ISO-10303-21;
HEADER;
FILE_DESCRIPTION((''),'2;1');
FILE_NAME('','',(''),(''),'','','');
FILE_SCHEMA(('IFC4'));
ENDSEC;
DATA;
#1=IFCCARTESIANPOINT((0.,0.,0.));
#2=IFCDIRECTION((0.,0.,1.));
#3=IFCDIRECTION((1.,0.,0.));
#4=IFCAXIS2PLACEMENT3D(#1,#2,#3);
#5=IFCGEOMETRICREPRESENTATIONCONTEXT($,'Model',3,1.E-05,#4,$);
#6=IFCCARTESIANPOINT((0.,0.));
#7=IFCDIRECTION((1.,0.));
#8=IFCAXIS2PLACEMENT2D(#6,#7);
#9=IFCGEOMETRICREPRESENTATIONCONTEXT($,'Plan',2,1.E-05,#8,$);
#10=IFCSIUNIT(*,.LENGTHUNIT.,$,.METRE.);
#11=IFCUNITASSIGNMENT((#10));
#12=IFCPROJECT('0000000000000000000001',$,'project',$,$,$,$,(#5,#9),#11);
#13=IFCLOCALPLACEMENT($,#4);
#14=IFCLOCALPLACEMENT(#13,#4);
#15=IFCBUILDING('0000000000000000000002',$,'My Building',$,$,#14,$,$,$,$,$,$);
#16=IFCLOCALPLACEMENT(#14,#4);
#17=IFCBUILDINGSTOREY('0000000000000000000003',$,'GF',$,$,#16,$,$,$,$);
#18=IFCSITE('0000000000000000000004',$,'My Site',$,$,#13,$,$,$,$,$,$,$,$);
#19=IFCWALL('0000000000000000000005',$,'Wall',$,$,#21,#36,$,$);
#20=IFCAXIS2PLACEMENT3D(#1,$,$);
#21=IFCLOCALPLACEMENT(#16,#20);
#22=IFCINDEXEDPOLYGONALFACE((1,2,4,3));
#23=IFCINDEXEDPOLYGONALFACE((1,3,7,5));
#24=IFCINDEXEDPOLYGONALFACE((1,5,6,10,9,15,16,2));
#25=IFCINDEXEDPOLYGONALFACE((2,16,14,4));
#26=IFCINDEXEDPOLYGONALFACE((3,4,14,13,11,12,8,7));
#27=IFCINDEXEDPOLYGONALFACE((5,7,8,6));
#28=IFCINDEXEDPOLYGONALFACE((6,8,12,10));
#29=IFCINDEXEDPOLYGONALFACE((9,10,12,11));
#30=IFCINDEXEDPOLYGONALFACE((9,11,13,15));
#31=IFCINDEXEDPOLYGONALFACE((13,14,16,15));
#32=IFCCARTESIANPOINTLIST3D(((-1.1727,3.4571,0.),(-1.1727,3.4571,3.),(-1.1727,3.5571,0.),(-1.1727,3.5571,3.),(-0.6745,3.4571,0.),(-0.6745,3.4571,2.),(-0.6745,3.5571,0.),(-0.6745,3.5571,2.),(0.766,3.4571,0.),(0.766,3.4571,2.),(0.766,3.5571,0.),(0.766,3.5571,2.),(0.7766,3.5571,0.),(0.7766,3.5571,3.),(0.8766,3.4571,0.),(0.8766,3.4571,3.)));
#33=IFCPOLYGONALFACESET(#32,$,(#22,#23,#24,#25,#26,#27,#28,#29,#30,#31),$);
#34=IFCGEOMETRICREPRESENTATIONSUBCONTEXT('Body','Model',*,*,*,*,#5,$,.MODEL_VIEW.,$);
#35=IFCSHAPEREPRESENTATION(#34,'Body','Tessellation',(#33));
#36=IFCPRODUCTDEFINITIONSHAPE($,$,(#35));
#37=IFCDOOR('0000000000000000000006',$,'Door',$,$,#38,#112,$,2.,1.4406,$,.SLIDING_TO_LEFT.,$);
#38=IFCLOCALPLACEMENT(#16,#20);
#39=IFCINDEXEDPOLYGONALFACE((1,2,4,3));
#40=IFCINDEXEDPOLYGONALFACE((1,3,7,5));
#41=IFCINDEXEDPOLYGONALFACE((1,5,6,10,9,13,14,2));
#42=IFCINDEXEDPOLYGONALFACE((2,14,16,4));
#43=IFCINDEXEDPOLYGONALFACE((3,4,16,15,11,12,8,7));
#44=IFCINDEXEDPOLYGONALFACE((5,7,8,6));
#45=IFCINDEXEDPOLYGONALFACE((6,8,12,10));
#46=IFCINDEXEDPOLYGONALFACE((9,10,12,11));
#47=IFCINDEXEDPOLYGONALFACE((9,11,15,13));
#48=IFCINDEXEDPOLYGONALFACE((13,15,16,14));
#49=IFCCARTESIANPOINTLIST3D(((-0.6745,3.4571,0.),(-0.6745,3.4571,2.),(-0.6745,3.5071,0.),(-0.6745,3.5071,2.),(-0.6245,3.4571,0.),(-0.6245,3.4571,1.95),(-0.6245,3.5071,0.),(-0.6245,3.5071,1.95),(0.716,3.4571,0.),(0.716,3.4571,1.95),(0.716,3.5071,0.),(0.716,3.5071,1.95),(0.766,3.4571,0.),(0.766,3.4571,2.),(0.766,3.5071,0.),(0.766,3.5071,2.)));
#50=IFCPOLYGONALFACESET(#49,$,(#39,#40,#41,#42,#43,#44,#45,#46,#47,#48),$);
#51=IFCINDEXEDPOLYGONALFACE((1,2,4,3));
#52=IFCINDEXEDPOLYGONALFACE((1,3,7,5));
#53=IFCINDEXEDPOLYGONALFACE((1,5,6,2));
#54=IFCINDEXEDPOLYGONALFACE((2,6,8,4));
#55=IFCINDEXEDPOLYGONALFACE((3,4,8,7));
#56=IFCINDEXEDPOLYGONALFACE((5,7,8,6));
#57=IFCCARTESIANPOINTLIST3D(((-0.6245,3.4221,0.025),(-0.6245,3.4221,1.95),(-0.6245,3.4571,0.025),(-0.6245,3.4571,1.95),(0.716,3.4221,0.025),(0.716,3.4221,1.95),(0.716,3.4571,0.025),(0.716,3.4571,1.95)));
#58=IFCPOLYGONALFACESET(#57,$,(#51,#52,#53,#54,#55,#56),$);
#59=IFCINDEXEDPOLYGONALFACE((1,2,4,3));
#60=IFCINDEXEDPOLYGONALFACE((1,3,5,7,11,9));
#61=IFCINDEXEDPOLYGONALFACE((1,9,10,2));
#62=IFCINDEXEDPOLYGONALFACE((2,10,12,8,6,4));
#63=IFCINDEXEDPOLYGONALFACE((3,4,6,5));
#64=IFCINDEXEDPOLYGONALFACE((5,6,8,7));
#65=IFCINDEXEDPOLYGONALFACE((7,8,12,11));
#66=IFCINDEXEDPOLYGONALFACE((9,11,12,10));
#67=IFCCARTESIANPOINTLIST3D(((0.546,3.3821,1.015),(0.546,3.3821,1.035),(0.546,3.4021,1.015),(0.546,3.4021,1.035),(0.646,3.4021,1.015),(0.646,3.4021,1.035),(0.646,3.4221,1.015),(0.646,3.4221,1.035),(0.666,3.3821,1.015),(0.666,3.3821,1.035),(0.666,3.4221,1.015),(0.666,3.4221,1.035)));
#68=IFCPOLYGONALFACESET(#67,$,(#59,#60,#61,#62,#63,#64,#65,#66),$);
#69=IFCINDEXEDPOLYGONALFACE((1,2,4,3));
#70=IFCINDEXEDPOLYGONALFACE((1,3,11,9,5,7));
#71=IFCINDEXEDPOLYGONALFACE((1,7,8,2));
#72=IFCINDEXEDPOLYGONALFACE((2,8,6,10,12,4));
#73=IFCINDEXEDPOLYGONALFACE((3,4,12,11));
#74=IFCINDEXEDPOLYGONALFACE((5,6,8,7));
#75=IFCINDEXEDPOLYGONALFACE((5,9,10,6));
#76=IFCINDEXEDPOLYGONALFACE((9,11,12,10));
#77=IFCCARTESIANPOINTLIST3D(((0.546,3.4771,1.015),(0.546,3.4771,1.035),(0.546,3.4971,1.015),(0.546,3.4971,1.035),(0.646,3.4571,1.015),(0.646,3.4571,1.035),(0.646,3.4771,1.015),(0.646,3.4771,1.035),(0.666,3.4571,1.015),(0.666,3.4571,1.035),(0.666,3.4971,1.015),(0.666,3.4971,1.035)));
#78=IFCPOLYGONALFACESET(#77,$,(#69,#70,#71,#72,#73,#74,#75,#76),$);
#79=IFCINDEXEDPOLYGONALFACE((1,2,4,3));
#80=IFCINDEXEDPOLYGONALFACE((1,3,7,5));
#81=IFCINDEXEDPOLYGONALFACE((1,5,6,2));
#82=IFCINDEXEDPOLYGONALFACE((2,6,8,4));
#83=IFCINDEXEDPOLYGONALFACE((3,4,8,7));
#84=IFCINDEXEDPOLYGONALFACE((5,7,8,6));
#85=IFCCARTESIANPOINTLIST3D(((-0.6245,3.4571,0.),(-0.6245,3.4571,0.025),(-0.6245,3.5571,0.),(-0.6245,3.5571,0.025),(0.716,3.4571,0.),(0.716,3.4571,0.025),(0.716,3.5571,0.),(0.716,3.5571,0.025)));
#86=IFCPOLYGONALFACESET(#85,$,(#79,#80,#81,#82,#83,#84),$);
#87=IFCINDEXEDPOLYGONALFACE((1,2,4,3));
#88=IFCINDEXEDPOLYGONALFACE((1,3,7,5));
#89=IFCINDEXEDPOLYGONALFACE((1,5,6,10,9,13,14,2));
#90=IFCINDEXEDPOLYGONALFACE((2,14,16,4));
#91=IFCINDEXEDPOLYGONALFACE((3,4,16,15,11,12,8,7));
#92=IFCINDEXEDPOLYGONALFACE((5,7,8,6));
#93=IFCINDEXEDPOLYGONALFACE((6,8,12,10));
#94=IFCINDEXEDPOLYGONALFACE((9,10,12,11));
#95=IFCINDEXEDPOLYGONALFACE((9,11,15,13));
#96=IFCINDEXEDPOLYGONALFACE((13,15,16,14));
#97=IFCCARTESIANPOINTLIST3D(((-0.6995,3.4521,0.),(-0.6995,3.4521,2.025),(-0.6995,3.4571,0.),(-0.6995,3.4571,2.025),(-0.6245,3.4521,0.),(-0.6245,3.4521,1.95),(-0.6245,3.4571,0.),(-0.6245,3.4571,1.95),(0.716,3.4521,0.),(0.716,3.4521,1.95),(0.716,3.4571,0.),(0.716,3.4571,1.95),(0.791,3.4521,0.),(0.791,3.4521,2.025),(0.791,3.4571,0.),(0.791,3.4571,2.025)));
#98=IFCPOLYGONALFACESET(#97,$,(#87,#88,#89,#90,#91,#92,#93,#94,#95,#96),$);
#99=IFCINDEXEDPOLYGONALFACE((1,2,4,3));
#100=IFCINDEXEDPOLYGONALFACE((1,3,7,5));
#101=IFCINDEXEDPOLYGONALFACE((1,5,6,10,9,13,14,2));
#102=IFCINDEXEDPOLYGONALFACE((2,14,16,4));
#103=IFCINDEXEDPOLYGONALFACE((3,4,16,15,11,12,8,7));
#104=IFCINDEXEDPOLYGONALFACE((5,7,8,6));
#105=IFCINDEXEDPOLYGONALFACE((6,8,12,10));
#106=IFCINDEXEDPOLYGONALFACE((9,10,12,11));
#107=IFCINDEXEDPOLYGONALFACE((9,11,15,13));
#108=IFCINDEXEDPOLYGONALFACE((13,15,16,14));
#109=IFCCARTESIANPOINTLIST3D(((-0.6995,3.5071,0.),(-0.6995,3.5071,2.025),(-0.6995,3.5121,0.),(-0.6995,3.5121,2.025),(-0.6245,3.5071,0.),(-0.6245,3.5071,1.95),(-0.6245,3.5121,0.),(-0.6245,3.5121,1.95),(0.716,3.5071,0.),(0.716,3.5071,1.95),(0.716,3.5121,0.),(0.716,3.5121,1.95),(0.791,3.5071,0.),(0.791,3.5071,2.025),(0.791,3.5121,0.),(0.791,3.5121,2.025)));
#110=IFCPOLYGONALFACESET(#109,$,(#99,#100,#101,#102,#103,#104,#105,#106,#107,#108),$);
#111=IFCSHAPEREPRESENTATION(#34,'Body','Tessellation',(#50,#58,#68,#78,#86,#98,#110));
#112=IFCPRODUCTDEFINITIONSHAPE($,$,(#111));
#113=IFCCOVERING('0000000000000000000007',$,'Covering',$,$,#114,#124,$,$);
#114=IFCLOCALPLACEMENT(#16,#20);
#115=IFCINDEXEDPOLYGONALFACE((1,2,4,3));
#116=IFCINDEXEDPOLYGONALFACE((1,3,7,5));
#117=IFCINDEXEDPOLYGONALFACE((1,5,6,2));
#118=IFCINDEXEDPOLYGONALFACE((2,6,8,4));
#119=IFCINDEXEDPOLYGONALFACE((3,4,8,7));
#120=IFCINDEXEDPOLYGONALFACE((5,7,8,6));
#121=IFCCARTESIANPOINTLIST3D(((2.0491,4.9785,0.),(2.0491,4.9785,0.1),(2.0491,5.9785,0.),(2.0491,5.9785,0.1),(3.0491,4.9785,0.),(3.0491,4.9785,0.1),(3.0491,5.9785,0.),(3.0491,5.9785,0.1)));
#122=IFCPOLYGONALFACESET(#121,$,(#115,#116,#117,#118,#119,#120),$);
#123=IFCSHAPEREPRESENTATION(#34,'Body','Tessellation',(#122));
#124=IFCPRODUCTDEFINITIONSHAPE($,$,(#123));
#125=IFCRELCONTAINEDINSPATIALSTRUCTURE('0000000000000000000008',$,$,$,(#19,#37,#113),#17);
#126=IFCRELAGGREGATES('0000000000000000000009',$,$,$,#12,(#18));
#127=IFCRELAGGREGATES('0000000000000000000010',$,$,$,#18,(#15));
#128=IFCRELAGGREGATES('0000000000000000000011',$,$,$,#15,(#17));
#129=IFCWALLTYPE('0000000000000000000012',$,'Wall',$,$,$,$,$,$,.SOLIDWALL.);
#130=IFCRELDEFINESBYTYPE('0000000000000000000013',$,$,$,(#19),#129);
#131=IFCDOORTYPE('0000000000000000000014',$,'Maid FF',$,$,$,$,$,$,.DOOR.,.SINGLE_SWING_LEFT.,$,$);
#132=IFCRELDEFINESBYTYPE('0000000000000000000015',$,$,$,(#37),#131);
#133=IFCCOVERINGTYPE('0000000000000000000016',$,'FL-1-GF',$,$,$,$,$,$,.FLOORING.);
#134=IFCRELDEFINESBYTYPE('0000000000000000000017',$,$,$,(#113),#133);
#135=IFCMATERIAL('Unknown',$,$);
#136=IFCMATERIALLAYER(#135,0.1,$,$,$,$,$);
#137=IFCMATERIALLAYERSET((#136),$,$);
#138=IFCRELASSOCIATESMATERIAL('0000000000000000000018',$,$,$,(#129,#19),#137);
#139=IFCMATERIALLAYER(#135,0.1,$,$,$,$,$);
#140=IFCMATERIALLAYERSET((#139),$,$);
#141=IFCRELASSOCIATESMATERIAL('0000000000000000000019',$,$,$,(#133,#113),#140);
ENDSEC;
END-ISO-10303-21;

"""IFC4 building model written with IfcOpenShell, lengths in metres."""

from ifc_helpers import new_model, entity, si_unit, frame, origin_with_axes, origin_2d_with_axis, place, context, subcontext, project, spatial, line, indexed_curve, outline, extrude, shape, source, transform, mapped, material, layer, layer_set, layer_usage, type_object, type_shapes, element, fill, save


model = new_model("IFC4")

# Units and contexts
model_context = context("Model", 3, precision=1e-05, world=origin_with_axes())
plan_context = context("Plan", 2, precision=1e-05, world=origin_2d_with_axis())
body_context_1 = subcontext(model_context, "Body", "Model", "MODEL_VIEW")
body_context_2 = subcontext(plan_context, "Body", "Plan", "PLAN_VIEW")
ifc_project = project(units=[si_unit("LENGTHUNIT", "METRE")], contexts=[model_context, plan_context])

# Site, building, storey
site_placement = place(None, origin_with_axes())
site = spatial("IfcSite", under=ifc_project, at=site_placement, Name="My Site")
building_placement = place(site_placement, origin_with_axes())
building = spatial("IfcBuilding", under=site, at=building_placement, Name="My Building")
storey_placement = place(building_placement, origin_with_axes())
storey = spatial("IfcBuildingStorey", under=building, at=storey_placement, Name="GF")

# Shared definitions
ifc_material = material(Name="Unknown")

# Shared definitions
ifc_layer_1 = layer(ifc_material, 0.1)
ifc_layer_set_1 = layer_set([ifc_layer_1])
wall_type = type_object("IfcWallType", Name="Wall", PredefinedType="SOLIDWALL", material=ifc_layer_set_1)

# Wall, opening, door
ifc_layer_usage_1 = layer_usage(ifc_layer_set_1, "AXIS2", "POSITIVE", 0.0)
wall_1_placement = place(storey_placement, frame((0.7766, 3.5571, 0.0), z_axis=(0.0, 0.0, 1.0), x_axis=(-1.0, 0.0, 0.0)))
wall_1 = element("IfcWall", 1, at=wall_1_placement, inside=storey, type_object=wall_type, material=ifc_layer_usage_1, Name="Wall", context=body_context_1, shape_type="SweptSolid", body=[
    extrude(outline(indexed_curve([(0.0, 0.0), (-0.1, 0.1), (1.9493, 0.1), (1.9493, 0.0)], segments=[line(1, 2, 3, 4, 1)])), origin_with_axes(), (0.0, 0.0, 1.0), 3.0),
])
shared_shape_1 = source(origin_with_axes(), body_context_1, "Body", "SweptSolid", [
    extrude(outline(indexed_curve([(0.0, 0.0), (1.4406, 0.0), (1.4406, 2.0), (0.0, 2.0)], segments=[line(1, 2, 3, 4, 1)])), frame((0.0, -0.6, 0.0), z_axis=(0.0, -1.0, 0.0), x_axis=(1.0, 0.0, 0.0)), (0.0, 0.0, -1.0), 1.2),
])
opening_1_placement = place(wall_1_placement, frame((1.4511, 0.1, 0.0), z_axis=(0.0, 0.0, 1.0), x_axis=(-1.0, 0.000001, 0.0)))
opening_1 = element("IfcOpeningElement", 2, at=opening_1_placement, cuts=wall_1, PredefinedType="OPENING", context=body_context_1, shape_type="MappedRepresentation", body=[
    mapped(shared_shape_1, transform((0.0, 0.0, 0.0), x_axis=(1.0, 0.0, 0.0), y_axis=(0.0, 1.0, 0.0), z_axis=(0.0, 0.0, 1.0), scale=1.0)),
])
door_type_1 = type_object("IfcDoorType", Name="Maid FF", OperationType="SINGLE_SWING_LEFT", PredefinedType="DOOR")
shared_shape_2 = source(origin_with_axes(), body_context_1, "Body", "SweptSolid", [
    extrude(outline(indexed_curve([(0.0, 0.0), (0.0, 2.0), (1.4406, 2.0), (1.4406, 0.0), (1.3906, 0.0), (1.3906, 1.95), (0.05, 1.95), (0.05, 0.0)], segments=[line(1, 2, 3, 4, 5, 6, 7, 8, 1)])), frame((0.0, 0.0, 0.0), z_axis=(0.0, -1.0, 0.0), x_axis=(1.0, 0.0, 0.0)), (0.0, 0.0, -1.0), 0.05),
    extrude(outline(indexed_curve([(0.0, 0.0), (1.3406, 0.0), (1.3406, 0.035), (0.0, 0.035)], segments=[line(1, 2, 3, 4, 1)])), frame((0.05, -0.035, 0.025), z_axis=(0.0, 0.0, 1.0), x_axis=(1.0, 0.0, 0.0)), (0.0, 0.0, 1.0), 1.925),
    extrude(outline(indexed_curve([(0.0, 0.0), (0.0, -0.04), (-0.12, -0.04), (-0.12, -0.02), (-0.02, -0.02), (-0.02, 0.0)], segments=[line(1, 2, 3, 4, 5, 6, 1)])), frame((1.3406, -0.035, 1.015), z_axis=(0.0, 0.0, 1.0), x_axis=(1.0, 0.0, 0.0)), (0.0, 0.0, 1.0), 0.02),
    extrude(outline(indexed_curve([(0.0, 0.0), (0.0, 0.04), (-0.12, 0.04), (-0.12, 0.02), (-0.02, 0.02), (-0.02, 0.0)], segments=[line(1, 2, 3, 4, 5, 6, 1)])), frame((1.3406, 0.0, 1.015), z_axis=(0.0, 0.0, 1.0), x_axis=(1.0, 0.0, 0.0)), (0.0, 0.0, 1.0), 0.02),
    extrude(outline(indexed_curve([(0.0, 0.0), (1.3406, 0.0), (1.3406, 0.1), (0.0, 0.1)], segments=[line(1, 2, 3, 4, 1)])), frame((0.05, 0.0, 0.0), z_axis=(0.0, 0.0, 1.0), x_axis=(1.0, 0.0, 0.0)), (0.0, 0.0, 1.0), 0.025),
    extrude(outline(indexed_curve([(0.0, 0.0), (0.0, 2.025), (1.4906, 2.025), (1.4906, 0.0), (1.4156, 0.0), (1.4156, 1.95), (0.075, 1.95), (0.075, 0.0)], segments=[line(1, 2, 3, 4, 5, 6, 7, 8, 1)])), frame((-0.025, -0.005, 0.0), z_axis=(0.0, -1.0, 0.0), x_axis=(1.0, 0.0, 0.0)), (0.0, 0.0, -1.0), 0.005),
    extrude(outline(indexed_curve([(0.0, 0.0), (0.0, 2.025), (1.4906, 2.025), (1.4906, 0.0), (1.4156, 0.0), (1.4156, 1.95), (0.075, 1.95), (0.075, 0.0)], segments=[line(1, 2, 3, 4, 5, 6, 7, 8, 1)])), frame((-0.025, 0.05, 0.0), z_axis=(0.0, -1.0, 0.0), x_axis=(1.0, 0.0, 0.0)), (0.0, 0.0, -1.0), 0.005),
])
shared_shape_3 = source(origin_with_axes(), body_context_2, "Body", "Curve2D", [
    entity("IfcIndexedPolyCurve", entity("IfcCartesianPointList2D", [[0.0, 0.0], [0.05, 0.0], [0.05, 0.05], [0.0, 0.05]]), [entity("IfcLineIndex", [1, 2, 3, 4, 1])]),
    entity("IfcIndexedPolyCurve", entity("IfcCartesianPointList2D", [[1.4406, 0.0], [1.3906, 0.0], [1.3906, 0.05], [1.4406, 0.05]]), [entity("IfcLineIndex", [1, 2, 3, 4, 1])]),
    entity("IfcIndexedPolyCurve", entity("IfcCartesianPointList2D", [[-0.6203, -0.035], [0.7203, -0.035], [0.7203, 0.0], [-0.6203, 0.0]]), [entity("IfcLineIndex", [1, 2, 3, 4, 1])]),
])
type_shapes(door_type_1, [shared_shape_2, shared_shape_3])
door_1_placement = place(opening_1_placement, frame((0.0, 0.0, 0.0), z_axis=(0.0, 0.0, 1.0), x_axis=(1.0, 0.0, 0.0)))
door_1 = element("IfcDoor", 3, at=door_1_placement, inside=storey, type_object=door_type_1, Name="Door", OperationType="SLIDING_TO_LEFT", OverallHeight=2.0, OverallWidth=1.4406, shapes=[
    shape(body_context_1, "Body", "MappedRepresentation", [mapped(shared_shape_2, transform((0.0, 0.0, 0.0), x_axis=(1.0, 0.0, 0.0), y_axis=(0.0, 1.0, 0.0), z_axis=(0.0, 0.0, 1.0), scale=1.0))]),
    shape(body_context_2, "Body", "MappedRepresentation", [mapped(shared_shape_3, transform((0.0, 0.0, 0.0), x_axis=(1.0, 0.0, 0.0), y_axis=(0.0, 1.0, 0.0), z_axis=(0.0, 0.0, 1.0), scale=1.0))]),
])
fill(opening_1, door_1)

# Covering
ifc_layer_2 = layer(ifc_material, 0.1)
ifc_layer_set_2 = layer_set([ifc_layer_2])
ifc_layer_usage_2 = layer_usage(ifc_layer_set_2, "AXIS3", "POSITIVE", 0.0)
covering_type = type_object("IfcCoveringType", Name="FL-1-GF", PredefinedType="FLOORING", material=ifc_layer_set_2)
covering_placement = place(storey_placement, frame((2.0491, 4.9785, 0.0), z_axis=(0.0, 0.0, 1.0), x_axis=(1.0, 0.0, 0.0)))
element("IfcCovering", 4, at=covering_placement, inside=storey, type_object=covering_type, material=ifc_layer_usage_2, Name="Covering", context=body_context_1, shape_type="SweptSolid", body=[
    extrude(outline(indexed_curve([(0.0, 0.0), (1.0, 0.0), (1.0, 1.0), (0.0, 1.0), (0.0, 0.0)])), None, (0.0, 0.0, 1.0), 0.1),
])

save(model, "model.ifc")
